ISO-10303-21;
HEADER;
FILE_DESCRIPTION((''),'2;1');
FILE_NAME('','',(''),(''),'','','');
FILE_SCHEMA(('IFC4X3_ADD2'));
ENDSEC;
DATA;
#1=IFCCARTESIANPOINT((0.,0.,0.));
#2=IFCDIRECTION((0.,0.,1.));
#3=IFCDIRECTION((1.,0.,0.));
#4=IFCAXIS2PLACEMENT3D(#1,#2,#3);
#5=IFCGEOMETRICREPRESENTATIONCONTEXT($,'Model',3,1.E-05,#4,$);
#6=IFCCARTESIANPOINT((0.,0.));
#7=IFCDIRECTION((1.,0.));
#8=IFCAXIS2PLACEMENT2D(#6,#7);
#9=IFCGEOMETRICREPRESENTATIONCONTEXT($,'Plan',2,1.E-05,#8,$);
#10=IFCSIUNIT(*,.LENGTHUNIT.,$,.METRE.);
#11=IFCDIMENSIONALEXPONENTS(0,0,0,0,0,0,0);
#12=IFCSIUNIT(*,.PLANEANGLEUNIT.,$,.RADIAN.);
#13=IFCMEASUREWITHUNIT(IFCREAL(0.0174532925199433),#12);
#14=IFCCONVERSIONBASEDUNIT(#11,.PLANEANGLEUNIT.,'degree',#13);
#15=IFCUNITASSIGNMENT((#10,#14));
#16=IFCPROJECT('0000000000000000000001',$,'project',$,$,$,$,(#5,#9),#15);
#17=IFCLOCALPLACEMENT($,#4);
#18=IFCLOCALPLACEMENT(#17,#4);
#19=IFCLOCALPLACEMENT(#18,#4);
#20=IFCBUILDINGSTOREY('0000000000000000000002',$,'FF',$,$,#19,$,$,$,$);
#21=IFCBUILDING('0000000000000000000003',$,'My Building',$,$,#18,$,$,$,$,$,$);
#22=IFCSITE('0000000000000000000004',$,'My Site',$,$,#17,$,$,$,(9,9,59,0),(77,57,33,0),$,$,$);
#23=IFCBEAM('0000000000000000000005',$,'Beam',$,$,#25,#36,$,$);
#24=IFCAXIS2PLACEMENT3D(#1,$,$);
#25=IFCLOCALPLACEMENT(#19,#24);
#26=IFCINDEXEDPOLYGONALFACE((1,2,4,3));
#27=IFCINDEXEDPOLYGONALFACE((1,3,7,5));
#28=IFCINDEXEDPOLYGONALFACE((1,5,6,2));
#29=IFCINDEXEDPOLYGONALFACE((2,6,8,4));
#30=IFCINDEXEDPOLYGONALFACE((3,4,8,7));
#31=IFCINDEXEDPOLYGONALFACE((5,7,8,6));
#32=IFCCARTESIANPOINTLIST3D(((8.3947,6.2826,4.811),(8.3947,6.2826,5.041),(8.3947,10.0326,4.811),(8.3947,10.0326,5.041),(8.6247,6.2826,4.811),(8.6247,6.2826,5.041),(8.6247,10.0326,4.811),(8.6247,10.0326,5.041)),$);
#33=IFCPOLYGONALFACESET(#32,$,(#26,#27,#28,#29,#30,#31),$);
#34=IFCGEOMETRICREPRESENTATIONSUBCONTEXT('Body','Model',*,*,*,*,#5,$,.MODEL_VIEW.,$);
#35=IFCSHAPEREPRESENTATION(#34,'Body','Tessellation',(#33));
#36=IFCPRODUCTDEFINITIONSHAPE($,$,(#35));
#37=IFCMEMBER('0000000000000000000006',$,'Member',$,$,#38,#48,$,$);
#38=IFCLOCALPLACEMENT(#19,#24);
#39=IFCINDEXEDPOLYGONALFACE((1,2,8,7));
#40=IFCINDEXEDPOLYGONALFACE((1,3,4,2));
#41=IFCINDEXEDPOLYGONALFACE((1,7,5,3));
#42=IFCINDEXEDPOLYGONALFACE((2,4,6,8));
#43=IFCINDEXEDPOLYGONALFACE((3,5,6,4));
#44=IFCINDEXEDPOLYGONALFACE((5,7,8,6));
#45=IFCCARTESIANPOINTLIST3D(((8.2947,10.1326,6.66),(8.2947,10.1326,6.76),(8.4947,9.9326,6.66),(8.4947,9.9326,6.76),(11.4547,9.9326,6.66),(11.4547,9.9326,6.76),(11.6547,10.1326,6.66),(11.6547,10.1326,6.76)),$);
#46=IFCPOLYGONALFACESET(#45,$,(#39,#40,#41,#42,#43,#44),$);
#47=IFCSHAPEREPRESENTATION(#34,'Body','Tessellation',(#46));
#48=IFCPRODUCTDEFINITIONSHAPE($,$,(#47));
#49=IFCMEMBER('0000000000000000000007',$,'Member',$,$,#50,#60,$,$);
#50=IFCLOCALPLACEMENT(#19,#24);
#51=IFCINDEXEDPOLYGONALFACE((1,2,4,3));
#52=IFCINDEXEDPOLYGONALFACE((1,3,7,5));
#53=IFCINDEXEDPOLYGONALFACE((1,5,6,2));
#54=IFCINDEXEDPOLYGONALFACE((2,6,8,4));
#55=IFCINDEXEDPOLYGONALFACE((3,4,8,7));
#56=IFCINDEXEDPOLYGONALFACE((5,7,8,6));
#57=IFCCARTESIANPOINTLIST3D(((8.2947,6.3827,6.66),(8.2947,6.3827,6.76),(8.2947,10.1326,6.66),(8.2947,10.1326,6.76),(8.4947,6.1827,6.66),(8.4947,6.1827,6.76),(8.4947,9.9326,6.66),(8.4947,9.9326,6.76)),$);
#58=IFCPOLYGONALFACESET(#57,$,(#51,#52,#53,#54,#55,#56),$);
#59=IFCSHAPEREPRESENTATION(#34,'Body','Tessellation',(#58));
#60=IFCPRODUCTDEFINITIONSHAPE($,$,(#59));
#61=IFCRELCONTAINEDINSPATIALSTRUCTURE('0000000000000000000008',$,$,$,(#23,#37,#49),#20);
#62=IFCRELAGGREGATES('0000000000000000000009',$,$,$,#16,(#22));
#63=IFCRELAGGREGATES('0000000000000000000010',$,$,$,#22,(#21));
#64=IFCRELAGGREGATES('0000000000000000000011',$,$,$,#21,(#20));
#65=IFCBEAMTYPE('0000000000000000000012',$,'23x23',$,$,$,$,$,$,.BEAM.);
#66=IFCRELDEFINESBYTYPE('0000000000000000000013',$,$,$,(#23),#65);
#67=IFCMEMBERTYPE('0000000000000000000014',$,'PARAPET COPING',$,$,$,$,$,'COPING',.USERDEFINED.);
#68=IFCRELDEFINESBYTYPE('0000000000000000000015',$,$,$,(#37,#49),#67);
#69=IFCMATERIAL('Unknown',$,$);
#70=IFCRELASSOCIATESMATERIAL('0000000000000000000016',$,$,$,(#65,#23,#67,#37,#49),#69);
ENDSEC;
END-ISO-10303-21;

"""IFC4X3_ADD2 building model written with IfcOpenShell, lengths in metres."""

from ifc_helpers import new_model, entity, si_unit, converted_unit, frame, origin_with_axes, origin_2d_with_axis, place, context, subcontext, project, spatial, rectangle, extrude, clip, halfspace, material, material_profile, profile_set, profile_usage, type_object, element, save


model = new_model("IFC4X3_ADD2")

# Units and contexts
model_context = context("Model", 3, precision=1e-05, world=origin_with_axes())
plan_context = context("Plan", 2, precision=1e-05, world=origin_2d_with_axis())
body_context_1 = subcontext(model_context, "Body", "Model", "MODEL_VIEW")
ifc_project = project(units=[si_unit("LENGTHUNIT", "METRE"), converted_unit("PLANEANGLEUNIT", "degree", entity("IfcReal", 0.0174532925199433), si_unit("PLANEANGLEUNIT", "RADIAN"), dimensions=[0, 0, 0, 0, 0, 0, 0])], contexts=[model_context, plan_context])

# Site, building, storey
site_placement = place(None, origin_with_axes())
site = spatial("IfcSite", under=ifc_project, at=site_placement, Name="My Site", RefLatitude=(9, 9, 59, 0), RefLongitude=(77, 57, 33, 0))
building_placement = place(site_placement, origin_with_axes())
building = spatial("IfcBuilding", under=site, at=building_placement, Name="My Building")
storey_placement = place(building_placement, origin_with_axes())
storey = spatial("IfcBuildingStorey", under=building, at=storey_placement, Name="FF")

# Beam
ifc_material = material(Name="Unknown")
ifc_material_profile_1 = material_profile(ifc_material, rectangle(XDim=0.23, YDim=0.23))
ifc_profile_set_1 = profile_set([ifc_material_profile_1])
ifc_profile_usage_1 = profile_usage(ifc_profile_set_1, cardinal=5)
beam_type = type_object("IfcBeamType", Name="23x23", PredefinedType="BEAM", material=ifc_profile_set_1)
beam_placement = place(storey_placement, frame((8.5097, 10.0326, 4.926), z_axis=(0.0, -1.0, 0.0), x_axis=(1.0, 0.0, 0.0)))
element("IfcBeam", 1, at=beam_placement, inside=storey, type_object=beam_type, material=ifc_profile_usage_1, Name="Beam", context=body_context_1, shape_type="SweptSolid", body=[
    extrude(rectangle(XDim=0.23, YDim=0.23), origin_with_axes(), (0.0, 0.0, 1.0), 3.75),
])

# Members
ifc_material_profile_2 = material_profile(ifc_material, rectangle(XDim=0.2, YDim=0.1))
ifc_profile_set_2 = profile_set([ifc_material_profile_2])
ifc_profile_usage_2 = profile_usage(ifc_profile_set_2, cardinal=5)
member_type = type_object("IfcMemberType", Name="PARAPET COPING", ElementType="COPING", PredefinedType="USERDEFINED", material=ifc_profile_set_2)
member_1_placement = place(storey_placement, frame((11.6547, 10.0326, 6.71), z_axis=(-1.0, 0.0, 0.0), x_axis=(0.0, -1.0, 0.0)))
element("IfcMember", 2, at=member_1_placement, inside=storey, type_object=member_type, material=ifc_profile_usage_2, Name="Member", context=body_context_1, shape_type="Clipping", body=[
    clip(clip(extrude(rectangle(XDim=0.2, YDim=0.1), origin_with_axes(), (0.0, 0.0, 1.0), 3.3601), halfspace(frame((-0.1, -6.66, 3.3601), z_axis=(0.707107, 0.0, 0.707107), x_axis=(0.0, -1.0, 0.0)), False)), halfspace(frame((-0.1, -6.66, 0.0), z_axis=(0.707107, 0.0, -0.707107), x_axis=(0.0, -1.0, 0.0)), False)),
])
ifc_profile_usage_3 = profile_usage(ifc_profile_set_2, cardinal=5)
member_2_placement = place(storey_placement, frame((8.3947, 10.1326, 6.71), z_axis=(0.0, -1.0, 0.0), x_axis=(1.0, 0.0, 0.0)))
element("IfcMember", 3, at=member_2_placement, inside=storey, type_object=member_type, material=ifc_profile_usage_3, Name="Member", context=body_context_1, shape_type="Clipping", body=[
    clip(clip(extrude(rectangle(XDim=0.2, YDim=0.1), origin_with_axes(), (0.0, 0.0, 1.0), 3.9499), halfspace(frame((0.1, -6.66, 3.9499), z_axis=(-0.707105, 0.0, 0.707109), x_axis=(0.0, 1.0, 0.0)), False)), halfspace(frame((-0.1, -6.66, 0.0), z_axis=(0.707107, 0.0, -0.707107), x_axis=(0.0, -1.0, 0.0)), False)),
])

save(model, "model.ifc")
